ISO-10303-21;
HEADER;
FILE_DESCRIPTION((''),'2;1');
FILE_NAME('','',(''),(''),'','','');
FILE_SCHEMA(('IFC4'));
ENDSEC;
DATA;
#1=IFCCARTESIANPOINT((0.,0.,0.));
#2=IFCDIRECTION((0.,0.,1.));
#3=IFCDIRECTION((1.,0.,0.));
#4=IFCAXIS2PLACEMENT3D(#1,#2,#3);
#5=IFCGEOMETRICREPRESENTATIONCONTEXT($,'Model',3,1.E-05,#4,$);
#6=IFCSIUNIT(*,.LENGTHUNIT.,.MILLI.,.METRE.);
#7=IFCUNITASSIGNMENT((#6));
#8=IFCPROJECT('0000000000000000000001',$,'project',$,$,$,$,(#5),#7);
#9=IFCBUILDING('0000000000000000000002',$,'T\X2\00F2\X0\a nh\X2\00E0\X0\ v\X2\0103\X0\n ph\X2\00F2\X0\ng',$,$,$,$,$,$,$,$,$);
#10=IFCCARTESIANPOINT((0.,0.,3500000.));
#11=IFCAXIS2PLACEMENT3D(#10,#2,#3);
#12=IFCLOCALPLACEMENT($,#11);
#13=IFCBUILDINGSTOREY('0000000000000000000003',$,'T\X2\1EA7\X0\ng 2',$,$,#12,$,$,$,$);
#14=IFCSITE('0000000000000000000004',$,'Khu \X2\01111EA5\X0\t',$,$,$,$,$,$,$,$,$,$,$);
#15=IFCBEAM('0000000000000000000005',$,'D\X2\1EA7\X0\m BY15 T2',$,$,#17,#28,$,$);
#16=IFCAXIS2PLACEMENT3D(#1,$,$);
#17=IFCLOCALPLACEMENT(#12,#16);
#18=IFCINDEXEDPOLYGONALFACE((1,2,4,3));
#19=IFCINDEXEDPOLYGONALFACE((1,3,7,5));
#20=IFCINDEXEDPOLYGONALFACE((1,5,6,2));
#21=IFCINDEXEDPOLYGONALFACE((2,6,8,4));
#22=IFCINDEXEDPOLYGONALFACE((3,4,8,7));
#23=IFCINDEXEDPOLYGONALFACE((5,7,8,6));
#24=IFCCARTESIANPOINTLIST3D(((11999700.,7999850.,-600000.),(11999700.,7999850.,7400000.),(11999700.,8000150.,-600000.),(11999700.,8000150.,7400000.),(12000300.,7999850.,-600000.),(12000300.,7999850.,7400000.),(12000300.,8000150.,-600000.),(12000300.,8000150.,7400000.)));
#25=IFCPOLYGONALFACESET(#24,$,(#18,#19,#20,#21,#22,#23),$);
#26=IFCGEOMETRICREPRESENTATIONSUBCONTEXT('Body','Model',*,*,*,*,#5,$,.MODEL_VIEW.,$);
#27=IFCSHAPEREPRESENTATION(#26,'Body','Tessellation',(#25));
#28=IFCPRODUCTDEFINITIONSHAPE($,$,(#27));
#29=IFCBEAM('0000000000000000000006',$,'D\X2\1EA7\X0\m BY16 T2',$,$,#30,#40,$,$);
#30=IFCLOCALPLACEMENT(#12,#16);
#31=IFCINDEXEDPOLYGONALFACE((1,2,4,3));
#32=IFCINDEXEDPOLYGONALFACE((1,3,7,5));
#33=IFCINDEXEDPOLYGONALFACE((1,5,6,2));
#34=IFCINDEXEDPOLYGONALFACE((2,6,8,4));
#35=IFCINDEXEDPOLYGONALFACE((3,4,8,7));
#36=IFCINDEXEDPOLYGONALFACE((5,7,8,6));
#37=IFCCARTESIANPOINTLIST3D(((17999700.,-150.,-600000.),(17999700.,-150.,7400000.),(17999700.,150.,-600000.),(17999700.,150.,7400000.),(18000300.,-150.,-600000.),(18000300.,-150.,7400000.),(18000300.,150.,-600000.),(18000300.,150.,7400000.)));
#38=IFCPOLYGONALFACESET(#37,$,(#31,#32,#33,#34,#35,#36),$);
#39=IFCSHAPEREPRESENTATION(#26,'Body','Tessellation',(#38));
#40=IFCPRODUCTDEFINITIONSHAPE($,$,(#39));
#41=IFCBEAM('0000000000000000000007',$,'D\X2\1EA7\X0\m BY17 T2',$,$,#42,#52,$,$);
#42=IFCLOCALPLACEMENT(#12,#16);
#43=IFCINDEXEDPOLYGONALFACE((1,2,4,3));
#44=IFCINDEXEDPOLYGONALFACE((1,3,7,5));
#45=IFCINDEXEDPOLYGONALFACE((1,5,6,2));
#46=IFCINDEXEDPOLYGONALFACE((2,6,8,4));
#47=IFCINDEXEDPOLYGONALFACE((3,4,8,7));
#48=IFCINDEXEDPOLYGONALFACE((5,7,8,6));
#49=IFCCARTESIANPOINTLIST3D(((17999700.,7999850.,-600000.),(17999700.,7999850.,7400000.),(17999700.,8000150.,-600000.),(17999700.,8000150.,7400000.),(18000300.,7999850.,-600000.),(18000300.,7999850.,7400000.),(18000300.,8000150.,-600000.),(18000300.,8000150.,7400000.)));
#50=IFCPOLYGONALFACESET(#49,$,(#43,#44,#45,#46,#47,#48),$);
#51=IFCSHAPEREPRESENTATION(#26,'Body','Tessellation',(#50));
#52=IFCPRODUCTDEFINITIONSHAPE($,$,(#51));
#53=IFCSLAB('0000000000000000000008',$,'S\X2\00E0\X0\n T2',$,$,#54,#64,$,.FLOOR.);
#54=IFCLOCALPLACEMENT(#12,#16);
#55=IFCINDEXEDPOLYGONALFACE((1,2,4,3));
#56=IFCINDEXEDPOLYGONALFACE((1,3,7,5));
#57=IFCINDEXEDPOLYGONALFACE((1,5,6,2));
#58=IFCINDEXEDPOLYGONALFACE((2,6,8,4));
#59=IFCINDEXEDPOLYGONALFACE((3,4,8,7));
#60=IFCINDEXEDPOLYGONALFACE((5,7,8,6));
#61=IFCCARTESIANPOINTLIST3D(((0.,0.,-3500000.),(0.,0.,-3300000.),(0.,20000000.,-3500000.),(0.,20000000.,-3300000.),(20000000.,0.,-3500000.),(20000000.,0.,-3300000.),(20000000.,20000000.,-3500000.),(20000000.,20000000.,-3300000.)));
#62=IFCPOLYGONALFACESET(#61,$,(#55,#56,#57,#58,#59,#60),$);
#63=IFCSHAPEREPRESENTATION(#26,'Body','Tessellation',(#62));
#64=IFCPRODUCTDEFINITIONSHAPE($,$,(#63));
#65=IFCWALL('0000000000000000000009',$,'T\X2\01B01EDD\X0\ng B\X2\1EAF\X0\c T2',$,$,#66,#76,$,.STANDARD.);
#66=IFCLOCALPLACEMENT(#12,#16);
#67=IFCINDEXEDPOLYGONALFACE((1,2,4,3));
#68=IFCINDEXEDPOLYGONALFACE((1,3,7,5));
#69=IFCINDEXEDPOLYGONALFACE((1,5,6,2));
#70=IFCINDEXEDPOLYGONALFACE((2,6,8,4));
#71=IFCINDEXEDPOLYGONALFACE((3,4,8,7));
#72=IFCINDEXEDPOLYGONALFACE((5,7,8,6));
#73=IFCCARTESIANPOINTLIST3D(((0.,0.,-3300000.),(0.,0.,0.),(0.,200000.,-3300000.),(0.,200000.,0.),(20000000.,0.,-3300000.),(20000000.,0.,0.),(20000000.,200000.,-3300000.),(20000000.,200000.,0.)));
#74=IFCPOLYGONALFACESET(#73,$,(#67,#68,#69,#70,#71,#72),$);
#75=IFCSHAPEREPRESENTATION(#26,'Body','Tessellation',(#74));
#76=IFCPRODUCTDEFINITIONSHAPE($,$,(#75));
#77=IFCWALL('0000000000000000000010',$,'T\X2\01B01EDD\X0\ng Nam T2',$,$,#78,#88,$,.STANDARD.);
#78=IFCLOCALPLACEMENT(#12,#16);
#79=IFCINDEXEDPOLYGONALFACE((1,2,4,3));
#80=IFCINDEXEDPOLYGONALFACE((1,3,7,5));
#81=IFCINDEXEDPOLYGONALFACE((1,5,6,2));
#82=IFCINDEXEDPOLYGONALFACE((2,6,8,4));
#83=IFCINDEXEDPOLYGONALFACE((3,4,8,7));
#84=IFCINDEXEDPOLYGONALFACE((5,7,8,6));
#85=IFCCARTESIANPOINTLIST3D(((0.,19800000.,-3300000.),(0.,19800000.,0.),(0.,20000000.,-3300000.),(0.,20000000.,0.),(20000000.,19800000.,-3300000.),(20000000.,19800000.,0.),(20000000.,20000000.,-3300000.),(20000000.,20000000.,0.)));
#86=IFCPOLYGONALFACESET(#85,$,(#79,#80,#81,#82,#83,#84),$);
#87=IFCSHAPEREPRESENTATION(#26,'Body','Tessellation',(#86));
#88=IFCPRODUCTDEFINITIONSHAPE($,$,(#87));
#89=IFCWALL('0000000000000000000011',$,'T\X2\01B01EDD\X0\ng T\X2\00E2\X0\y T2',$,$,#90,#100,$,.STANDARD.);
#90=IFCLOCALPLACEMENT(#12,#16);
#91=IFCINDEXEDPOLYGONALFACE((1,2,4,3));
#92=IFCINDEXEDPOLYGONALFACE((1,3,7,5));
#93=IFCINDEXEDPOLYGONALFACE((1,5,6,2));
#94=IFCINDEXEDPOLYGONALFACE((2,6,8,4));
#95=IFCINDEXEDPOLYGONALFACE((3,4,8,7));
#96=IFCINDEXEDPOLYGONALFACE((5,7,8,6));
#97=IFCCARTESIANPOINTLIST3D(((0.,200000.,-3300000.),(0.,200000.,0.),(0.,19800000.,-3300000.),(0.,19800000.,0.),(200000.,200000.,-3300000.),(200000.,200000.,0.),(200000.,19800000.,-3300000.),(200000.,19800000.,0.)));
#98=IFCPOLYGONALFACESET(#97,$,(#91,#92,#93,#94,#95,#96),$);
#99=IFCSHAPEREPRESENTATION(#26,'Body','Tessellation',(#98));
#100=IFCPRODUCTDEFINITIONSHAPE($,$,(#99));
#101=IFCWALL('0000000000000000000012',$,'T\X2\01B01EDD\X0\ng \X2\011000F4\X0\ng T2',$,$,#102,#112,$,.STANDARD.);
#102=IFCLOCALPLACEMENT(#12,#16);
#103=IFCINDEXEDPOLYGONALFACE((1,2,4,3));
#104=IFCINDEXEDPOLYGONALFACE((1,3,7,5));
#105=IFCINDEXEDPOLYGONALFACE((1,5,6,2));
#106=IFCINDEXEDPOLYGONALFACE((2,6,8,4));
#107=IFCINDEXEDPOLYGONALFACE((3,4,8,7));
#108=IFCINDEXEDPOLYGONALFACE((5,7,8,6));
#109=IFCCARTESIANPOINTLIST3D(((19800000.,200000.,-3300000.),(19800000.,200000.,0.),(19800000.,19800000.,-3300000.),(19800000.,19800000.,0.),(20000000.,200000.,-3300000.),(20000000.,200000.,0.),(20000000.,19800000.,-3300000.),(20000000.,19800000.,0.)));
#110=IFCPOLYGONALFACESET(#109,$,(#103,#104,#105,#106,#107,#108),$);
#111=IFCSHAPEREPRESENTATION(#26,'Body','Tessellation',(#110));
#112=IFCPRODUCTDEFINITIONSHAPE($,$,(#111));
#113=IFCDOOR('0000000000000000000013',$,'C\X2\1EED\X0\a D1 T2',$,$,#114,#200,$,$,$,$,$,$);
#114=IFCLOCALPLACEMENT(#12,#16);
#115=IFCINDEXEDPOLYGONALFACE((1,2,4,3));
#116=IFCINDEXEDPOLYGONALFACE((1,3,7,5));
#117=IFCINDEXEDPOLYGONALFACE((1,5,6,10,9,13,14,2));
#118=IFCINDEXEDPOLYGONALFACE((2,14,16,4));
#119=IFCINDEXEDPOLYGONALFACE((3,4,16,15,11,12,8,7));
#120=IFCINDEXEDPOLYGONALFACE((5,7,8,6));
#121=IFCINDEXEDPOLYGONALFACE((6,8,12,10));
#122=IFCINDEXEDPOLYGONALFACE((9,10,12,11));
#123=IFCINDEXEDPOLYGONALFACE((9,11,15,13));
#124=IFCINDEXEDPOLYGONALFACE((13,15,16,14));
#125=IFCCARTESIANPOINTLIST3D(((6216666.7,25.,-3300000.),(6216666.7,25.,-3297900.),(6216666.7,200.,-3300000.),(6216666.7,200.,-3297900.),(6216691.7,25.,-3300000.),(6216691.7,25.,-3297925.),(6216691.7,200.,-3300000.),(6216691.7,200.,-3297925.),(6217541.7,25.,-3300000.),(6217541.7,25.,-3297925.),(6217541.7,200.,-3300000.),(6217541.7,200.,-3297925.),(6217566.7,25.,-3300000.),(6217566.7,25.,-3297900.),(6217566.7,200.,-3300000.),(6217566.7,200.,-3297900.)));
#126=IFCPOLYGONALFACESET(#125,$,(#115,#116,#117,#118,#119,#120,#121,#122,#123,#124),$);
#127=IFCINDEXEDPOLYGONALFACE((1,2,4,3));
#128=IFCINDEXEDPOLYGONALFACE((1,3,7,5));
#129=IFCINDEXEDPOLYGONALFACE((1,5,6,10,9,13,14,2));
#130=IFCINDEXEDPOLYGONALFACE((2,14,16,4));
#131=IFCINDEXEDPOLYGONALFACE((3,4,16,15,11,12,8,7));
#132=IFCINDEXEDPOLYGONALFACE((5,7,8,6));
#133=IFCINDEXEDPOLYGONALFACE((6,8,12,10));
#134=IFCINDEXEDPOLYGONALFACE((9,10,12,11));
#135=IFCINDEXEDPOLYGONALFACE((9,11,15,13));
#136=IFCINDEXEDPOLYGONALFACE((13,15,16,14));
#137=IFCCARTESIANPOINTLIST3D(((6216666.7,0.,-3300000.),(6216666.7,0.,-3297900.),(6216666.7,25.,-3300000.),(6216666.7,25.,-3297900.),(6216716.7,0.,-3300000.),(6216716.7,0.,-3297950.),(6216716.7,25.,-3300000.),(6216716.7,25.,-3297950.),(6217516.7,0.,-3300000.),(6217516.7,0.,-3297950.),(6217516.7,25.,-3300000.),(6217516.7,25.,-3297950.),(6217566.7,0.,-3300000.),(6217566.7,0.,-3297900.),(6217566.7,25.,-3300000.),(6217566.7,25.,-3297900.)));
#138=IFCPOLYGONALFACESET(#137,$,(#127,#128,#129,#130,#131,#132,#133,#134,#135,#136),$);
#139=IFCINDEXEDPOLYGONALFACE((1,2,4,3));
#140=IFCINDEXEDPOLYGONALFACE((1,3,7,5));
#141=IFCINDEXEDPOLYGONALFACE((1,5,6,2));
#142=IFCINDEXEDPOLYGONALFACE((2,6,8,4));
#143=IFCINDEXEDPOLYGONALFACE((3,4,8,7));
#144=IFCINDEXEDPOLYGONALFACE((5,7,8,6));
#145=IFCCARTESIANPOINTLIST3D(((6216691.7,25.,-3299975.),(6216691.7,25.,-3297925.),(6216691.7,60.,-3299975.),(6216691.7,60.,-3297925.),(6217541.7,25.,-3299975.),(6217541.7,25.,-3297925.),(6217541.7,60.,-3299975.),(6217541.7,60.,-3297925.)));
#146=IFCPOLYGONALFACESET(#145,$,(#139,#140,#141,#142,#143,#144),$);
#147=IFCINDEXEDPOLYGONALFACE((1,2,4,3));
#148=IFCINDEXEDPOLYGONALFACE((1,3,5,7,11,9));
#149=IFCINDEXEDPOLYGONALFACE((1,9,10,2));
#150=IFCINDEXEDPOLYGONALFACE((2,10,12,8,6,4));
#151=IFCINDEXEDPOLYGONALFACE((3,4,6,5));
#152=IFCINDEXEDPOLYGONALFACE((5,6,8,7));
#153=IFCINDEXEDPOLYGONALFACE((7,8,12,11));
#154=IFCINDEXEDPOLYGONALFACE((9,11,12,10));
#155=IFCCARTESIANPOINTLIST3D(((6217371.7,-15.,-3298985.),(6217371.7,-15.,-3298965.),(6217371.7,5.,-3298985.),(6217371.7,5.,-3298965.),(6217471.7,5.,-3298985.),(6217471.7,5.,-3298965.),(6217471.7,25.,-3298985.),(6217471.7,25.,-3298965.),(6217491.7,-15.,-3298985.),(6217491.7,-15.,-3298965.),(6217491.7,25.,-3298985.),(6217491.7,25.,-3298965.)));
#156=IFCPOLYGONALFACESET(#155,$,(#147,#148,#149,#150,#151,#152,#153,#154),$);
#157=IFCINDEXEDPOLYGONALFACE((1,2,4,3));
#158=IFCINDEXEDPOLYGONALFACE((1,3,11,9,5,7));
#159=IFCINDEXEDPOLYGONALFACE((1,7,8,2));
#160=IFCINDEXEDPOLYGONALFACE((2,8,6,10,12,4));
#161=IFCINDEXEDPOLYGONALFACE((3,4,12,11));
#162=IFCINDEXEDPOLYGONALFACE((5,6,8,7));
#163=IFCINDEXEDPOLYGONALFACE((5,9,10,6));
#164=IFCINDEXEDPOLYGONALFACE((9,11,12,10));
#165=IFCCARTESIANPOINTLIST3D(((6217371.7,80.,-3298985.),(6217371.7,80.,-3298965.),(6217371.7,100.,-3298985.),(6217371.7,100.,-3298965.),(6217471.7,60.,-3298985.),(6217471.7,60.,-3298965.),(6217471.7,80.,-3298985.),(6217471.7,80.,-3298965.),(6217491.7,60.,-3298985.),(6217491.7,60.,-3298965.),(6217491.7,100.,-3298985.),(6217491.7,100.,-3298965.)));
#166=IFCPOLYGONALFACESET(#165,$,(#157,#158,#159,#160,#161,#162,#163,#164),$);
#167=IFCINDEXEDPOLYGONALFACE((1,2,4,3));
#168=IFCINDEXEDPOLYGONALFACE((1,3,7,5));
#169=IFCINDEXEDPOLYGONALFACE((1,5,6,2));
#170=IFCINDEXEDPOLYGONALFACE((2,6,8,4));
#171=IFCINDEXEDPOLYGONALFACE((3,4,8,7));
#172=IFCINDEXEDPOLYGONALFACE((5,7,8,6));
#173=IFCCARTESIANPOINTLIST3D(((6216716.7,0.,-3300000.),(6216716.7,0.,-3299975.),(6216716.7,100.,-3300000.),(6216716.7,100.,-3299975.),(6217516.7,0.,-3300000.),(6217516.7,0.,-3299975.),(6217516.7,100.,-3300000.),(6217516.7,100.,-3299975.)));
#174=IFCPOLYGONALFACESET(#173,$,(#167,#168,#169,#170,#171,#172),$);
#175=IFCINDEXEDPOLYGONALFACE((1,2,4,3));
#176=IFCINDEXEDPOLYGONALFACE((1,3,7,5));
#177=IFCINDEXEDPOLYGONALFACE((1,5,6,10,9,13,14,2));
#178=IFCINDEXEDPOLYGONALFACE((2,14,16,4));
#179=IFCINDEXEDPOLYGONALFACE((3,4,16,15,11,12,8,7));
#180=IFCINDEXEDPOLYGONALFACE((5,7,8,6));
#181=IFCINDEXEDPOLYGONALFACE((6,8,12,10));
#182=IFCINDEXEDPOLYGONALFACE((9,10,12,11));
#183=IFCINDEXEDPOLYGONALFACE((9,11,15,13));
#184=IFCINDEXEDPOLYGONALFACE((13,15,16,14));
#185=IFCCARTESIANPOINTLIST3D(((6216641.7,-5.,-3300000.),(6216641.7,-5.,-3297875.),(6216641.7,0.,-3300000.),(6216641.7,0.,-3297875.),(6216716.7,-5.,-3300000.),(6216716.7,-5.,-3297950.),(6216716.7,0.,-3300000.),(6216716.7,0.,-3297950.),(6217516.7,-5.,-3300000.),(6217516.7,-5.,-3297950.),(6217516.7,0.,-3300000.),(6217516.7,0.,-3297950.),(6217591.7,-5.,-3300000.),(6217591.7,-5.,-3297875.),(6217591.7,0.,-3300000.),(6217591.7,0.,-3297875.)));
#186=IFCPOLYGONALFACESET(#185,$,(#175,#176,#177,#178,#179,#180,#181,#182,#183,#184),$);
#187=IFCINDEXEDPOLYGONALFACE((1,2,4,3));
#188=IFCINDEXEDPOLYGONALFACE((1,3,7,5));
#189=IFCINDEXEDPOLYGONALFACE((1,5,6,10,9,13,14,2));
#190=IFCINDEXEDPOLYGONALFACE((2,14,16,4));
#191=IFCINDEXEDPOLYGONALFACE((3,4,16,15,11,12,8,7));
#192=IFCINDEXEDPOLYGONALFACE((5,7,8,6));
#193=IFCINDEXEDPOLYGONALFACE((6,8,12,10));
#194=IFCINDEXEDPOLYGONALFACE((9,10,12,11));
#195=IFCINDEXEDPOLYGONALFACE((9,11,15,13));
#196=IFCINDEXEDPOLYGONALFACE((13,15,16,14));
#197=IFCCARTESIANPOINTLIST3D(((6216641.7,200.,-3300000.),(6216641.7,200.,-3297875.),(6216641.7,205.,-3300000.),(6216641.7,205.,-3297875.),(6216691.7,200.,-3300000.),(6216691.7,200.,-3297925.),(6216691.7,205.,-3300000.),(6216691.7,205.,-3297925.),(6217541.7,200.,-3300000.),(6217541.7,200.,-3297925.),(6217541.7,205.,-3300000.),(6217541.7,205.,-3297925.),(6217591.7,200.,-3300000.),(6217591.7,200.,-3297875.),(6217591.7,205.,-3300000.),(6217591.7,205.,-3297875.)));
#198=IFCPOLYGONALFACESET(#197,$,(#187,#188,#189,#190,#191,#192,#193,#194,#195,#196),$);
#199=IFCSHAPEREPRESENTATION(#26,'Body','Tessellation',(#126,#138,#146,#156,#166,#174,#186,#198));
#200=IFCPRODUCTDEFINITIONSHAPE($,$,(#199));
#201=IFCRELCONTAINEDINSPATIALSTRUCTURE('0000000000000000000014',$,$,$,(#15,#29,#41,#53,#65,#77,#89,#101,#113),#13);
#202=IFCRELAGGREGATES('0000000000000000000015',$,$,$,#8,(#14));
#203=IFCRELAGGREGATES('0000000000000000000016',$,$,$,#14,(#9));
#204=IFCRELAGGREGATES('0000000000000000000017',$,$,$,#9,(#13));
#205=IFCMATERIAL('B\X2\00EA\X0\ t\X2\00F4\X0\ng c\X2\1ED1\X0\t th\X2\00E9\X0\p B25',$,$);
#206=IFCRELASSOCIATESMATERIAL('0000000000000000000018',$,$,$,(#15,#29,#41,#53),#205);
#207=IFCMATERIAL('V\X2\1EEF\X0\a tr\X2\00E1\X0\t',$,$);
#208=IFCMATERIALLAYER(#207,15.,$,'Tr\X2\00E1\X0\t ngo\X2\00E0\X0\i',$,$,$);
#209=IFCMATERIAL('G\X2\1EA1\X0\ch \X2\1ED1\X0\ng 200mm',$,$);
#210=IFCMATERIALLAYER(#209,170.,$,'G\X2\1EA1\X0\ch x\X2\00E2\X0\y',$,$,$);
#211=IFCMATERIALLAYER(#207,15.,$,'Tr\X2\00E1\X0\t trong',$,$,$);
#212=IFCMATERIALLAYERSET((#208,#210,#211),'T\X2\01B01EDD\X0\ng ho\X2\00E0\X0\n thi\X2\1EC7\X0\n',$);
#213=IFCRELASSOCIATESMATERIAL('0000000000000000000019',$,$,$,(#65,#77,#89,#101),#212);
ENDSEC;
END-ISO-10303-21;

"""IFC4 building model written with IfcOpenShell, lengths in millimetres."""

from ifc_helpers import new_model, entity, si_unit, frame, origin_with_axes, place, context, subcontext, project, spatial, line, indexed_curve, outline, extrude, material, layer, layer_set, layer_usage, element, save


model = new_model("IFC4")

# Units and contexts
model_context = context("Model", 3, precision=1e-05, world=origin_with_axes())
body_context = subcontext(model_context, "Body", "Model", "MODEL_VIEW")
ifc_project = project(units=[si_unit("LENGTHUNIT", "METRE", prefix="MILLI")], contexts=[model_context])

# Site, building, storey
site = spatial("IfcSite", under=ifc_project, Name="Khu đất")
building = spatial("IfcBuilding", under=site, Name="Tòa nhà văn phòng")
storey_placement = place(None, frame((0.0, 0.0, 3500000.0), z_axis=(0.0, 0.0, 1.0), x_axis=(1.0, 0.0, 0.0)))
storey = spatial("IfcBuildingStorey", under=building, at=storey_placement, Name="Tầng 2")

# Shared definitions
ifc_material_1 = material(Name="Bê tông cốt thép B25")

# Beams
for number, where, z_axis, x_axis, name in (
    (1, (12000000.0, 8000000.0, -600000.0), (0.0, 0.0, 1.0), (0.0, 1.0, 0.0), "Dầm BY15 T2"),
    (2, (18000000.0, 0.0, -600000.0), (0.0, 0.0, 1.0), (0.0, 1.0, 0.0), "Dầm BY16 T2"),
    (3, (18000000.0, 8000000.0, -600000.0), (0.0, 0.0, 1.0), (0.0, 1.0, 0.0), "Dầm BY17 T2"),
):
    element("IfcBeam", number, at=place(storey_placement, frame(where, z_axis=z_axis, x_axis=x_axis)), inside=storey, material=ifc_material_1, Name=name, context=body_context, shape_type="SweptSolid", body=[
        extrude(entity("IfcRectangleProfileDef", None, None, None, 300.0, 600.0), origin_with_axes(), (0.0, 0.0, 1.0), 8000000.0),
    ])

# Slab
slab_placement = place(storey_placement, frame((0.0, 0.0, -3500000.0), z_axis=(0.0, 0.0, 1.0), x_axis=(1.0, 0.0, 0.0)))
element("IfcSlab", 4, at=slab_placement, inside=storey, material=ifc_material_1, Name="Sàn T2", PredefinedType="FLOOR", context=body_context, shape_type="SweptSolid", body=[
    extrude(outline(indexed_curve([(0.0, 0.0), (20000000.0, 0.0), (20000000.0, 20000000.0), (0.0, 20000000.0), (0.0, 0.0)])), None, (0.0, 0.0, 1.0), 200000.0),
])

# Walls
ifc_material_2 = material(Name="Vữa trát")
ifc_layer_1 = layer(ifc_material_2, 15.0, Name="Trát ngoài")
ifc_material_3 = material(Name="Gạch ống 200mm")
ifc_layer_2 = layer(ifc_material_3, 170.0, Name="Gạch xây")
ifc_layer_3 = layer(ifc_material_2, 15.0, Name="Trát trong")
ifc_layer_set = layer_set([ifc_layer_1, ifc_layer_2, ifc_layer_3], Name="Tường hoàn thiện")
ifc_layer_usage_1 = layer_usage(ifc_layer_set, "AXIS2", "POSITIVE", 0.0)
wall_1_placement = place(storey_placement, frame((0.0, 0.0, -3300000.0), z_axis=(0.0, 0.0, 1.0), x_axis=(1.0, 0.0, 0.0)))
element("IfcWall", 5, at=wall_1_placement, inside=storey, material=ifc_layer_usage_1, Name="Tường Bắc T2", PredefinedType="STANDARD", context=body_context, shape_type="SweptSolid", body=[
    extrude(outline(indexed_curve([(0.0, 0.0), (0.0, 200000.0), (20000000.0, 200000.0), (20000000.0, 0.0), (0.0, 0.0)], self_intersect=False)), origin_with_axes(), (0.0, 0.0, 1.0), 3300000.0),
])
ifc_layer_usage_2 = layer_usage(ifc_layer_set, "AXIS2", "POSITIVE", 0.0)
wall_2_placement = place(storey_placement, frame((0.0, 19800000.0, -3300000.0), z_axis=(0.0, 0.0, 1.0), x_axis=(1.0, 0.0, 0.0)))
element("IfcWall", 6, at=wall_2_placement, inside=storey, material=ifc_layer_usage_2, Name="Tường Nam T2", PredefinedType="STANDARD", context=body_context, shape_type="SweptSolid", body=[
    extrude(outline(indexed_curve([(0.0, 0.0), (0.0, 200000.0), (20000000.0, 200000.0), (20000000.0, 0.0), (0.0, 0.0)], self_intersect=False)), origin_with_axes(), (0.0, 0.0, 1.0), 3300000.0),
])
ifc_layer_usage_3 = layer_usage(ifc_layer_set, "AXIS2", "POSITIVE", 0.0)
wall_3_placement = place(storey_placement, frame((0.0, 200000.0, -3300000.0), z_axis=(0.0, 0.0, 1.0), x_axis=(1.0, 0.0, 0.0)))
element("IfcWall", 7, at=wall_3_placement, inside=storey, material=ifc_layer_usage_3, Name="Tường Tây T2", PredefinedType="STANDARD", context=body_context, shape_type="SweptSolid", body=[
    extrude(outline(indexed_curve([(0.0, 0.0), (0.0, 19600000.0), (200000.0, 19600000.0), (200000.0, 0.0), (0.0, 0.0)], self_intersect=False)), origin_with_axes(), (0.0, 0.0, 1.0), 3300000.0),
])
ifc_layer_usage_4 = layer_usage(ifc_layer_set, "AXIS2", "POSITIVE", 0.0)
wall_4_placement = place(storey_placement, frame((19800000.0, 200000.0, -3300000.0), z_axis=(0.0, 0.0, 1.0), x_axis=(1.0, 0.0, 0.0)))
element("IfcWall", 8, at=wall_4_placement, inside=storey, material=ifc_layer_usage_4, Name="Tường Đông T2", PredefinedType="STANDARD", context=body_context, shape_type="SweptSolid", body=[
    extrude(outline(indexed_curve([(0.0, 0.0), (0.0, 19600000.0), (200000.0, 19600000.0), (200000.0, 0.0), (0.0, 0.0)], self_intersect=False)), origin_with_axes(), (0.0, 0.0, 1.0), 3300000.0),
])

# Door
door_1_placement = place(storey_placement, frame((6216666.7, 0.0, -3300000.0), z_axis=(0.0, 0.0, 1.0), x_axis=(1.0, 0.0, 0.0)))
element("IfcDoor", 9, at=door_1_placement, inside=storey, Name="Cửa D1 T2", context=body_context, shape_type="SolidModel", body=[
    extrude(outline(indexed_curve([(0.0, 0.0), (0.0, 2100.0), (900.0, 2100.0), (900.0, 0.0), (875.0, 0.0), (875.0, 2075.0), (25.0, 2075.0), (25.0, 0.0)], segments=[line(1, 2, 3, 4, 5, 6, 7, 8, 1)])), frame((0.0, 25.0, 0.0), z_axis=(0.0, -1.0, 0.0), x_axis=(1.0, 0.0, 0.0)), (0.0, 0.0, -1.0), 175.0),
    extrude(outline(indexed_curve([(0.0, 0.0), (0.0, 2100.0), (900.0, 2100.0), (900.0, 0.0), (850.0, 0.0), (850.0, 2050.0), (50.0, 2050.0), (50.0, 0.0)], segments=[line(1, 2, 3, 4, 5, 6, 7, 8, 1)])), frame((0.0, 0.0, 0.0), z_axis=(0.0, -1.0, 0.0), x_axis=(1.0, 0.0, 0.0)), (0.0, 0.0, -1.0), 25.0),
    extrude(outline(indexed_curve([(0.0, 0.0), (850.0, 0.0), (850.0, 35.0), (0.0, 35.0)], segments=[line(1, 2, 3, 4, 1)])), frame((25.0, 25.0, 25.0), z_axis=(0.0, 0.0, 1.0), x_axis=(1.0, 0.0, 0.0)), (0.0, 0.0, 1.0), 2050.0),
    extrude(outline(indexed_curve([(0.0, 0.0), (0.0, -40.0), (-120.0, -40.0), (-120.0, -20.0), (-20.0, -20.0), (-20.0, 0.0)], segments=[line(1, 2, 3, 4, 5, 6, 1)])), frame((825.0, 25.0, 1015.0), z_axis=(0.0, 0.0, 1.0), x_axis=(1.0, 0.0, 0.0)), (0.0, 0.0, 1.0), 20.0),
    extrude(outline(indexed_curve([(0.0, 0.0), (0.0, 40.0), (-120.0, 40.0), (-120.0, 20.0), (-20.0, 20.0), (-20.0, 0.0)], segments=[line(1, 2, 3, 4, 5, 6, 1)])), frame((825.0, 60.0, 1015.0), z_axis=(0.0, 0.0, 1.0), x_axis=(1.0, 0.0, 0.0)), (0.0, 0.0, 1.0), 20.0),
    extrude(outline(indexed_curve([(0.0, 0.0), (800.0, 0.0), (800.0, 100.0), (0.0, 100.0)], segments=[line(1, 2, 3, 4, 1)])), frame((50.0, 0.0, 0.0), z_axis=(0.0, 0.0, 1.0), x_axis=(1.0, 0.0, 0.0)), (0.0, 0.0, 1.0), 25.0),
    extrude(outline(indexed_curve([(0.0, 0.0), (0.0, 2125.0), (950.0, 2125.0), (950.0, 0.0), (875.0, 0.0), (875.0, 2050.0), (75.0, 2050.0), (75.0, 0.0)], segments=[line(1, 2, 3, 4, 5, 6, 7, 8, 1)])), frame((-25.0, -5.0, 0.0), z_axis=(0.0, -1.0, 0.0), x_axis=(1.0, 0.0, 0.0)), (0.0, 0.0, -1.0), 5.0),
    extrude(outline(indexed_curve([(0.0, 0.0), (0.0, 2125.0), (950.0, 2125.0), (950.0, 0.0), (900.0, 0.0), (900.0, 2075.0), (50.0, 2075.0), (50.0, 0.0)], segments=[line(1, 2, 3, 4, 5, 6, 7, 8, 1)])), frame((-25.0, 200.0, 0.0), z_axis=(0.0, -1.0, 0.0), x_axis=(1.0, 0.0, 0.0)), (0.0, 0.0, -1.0), 5.0),
])

save(model, "model.ifc")
